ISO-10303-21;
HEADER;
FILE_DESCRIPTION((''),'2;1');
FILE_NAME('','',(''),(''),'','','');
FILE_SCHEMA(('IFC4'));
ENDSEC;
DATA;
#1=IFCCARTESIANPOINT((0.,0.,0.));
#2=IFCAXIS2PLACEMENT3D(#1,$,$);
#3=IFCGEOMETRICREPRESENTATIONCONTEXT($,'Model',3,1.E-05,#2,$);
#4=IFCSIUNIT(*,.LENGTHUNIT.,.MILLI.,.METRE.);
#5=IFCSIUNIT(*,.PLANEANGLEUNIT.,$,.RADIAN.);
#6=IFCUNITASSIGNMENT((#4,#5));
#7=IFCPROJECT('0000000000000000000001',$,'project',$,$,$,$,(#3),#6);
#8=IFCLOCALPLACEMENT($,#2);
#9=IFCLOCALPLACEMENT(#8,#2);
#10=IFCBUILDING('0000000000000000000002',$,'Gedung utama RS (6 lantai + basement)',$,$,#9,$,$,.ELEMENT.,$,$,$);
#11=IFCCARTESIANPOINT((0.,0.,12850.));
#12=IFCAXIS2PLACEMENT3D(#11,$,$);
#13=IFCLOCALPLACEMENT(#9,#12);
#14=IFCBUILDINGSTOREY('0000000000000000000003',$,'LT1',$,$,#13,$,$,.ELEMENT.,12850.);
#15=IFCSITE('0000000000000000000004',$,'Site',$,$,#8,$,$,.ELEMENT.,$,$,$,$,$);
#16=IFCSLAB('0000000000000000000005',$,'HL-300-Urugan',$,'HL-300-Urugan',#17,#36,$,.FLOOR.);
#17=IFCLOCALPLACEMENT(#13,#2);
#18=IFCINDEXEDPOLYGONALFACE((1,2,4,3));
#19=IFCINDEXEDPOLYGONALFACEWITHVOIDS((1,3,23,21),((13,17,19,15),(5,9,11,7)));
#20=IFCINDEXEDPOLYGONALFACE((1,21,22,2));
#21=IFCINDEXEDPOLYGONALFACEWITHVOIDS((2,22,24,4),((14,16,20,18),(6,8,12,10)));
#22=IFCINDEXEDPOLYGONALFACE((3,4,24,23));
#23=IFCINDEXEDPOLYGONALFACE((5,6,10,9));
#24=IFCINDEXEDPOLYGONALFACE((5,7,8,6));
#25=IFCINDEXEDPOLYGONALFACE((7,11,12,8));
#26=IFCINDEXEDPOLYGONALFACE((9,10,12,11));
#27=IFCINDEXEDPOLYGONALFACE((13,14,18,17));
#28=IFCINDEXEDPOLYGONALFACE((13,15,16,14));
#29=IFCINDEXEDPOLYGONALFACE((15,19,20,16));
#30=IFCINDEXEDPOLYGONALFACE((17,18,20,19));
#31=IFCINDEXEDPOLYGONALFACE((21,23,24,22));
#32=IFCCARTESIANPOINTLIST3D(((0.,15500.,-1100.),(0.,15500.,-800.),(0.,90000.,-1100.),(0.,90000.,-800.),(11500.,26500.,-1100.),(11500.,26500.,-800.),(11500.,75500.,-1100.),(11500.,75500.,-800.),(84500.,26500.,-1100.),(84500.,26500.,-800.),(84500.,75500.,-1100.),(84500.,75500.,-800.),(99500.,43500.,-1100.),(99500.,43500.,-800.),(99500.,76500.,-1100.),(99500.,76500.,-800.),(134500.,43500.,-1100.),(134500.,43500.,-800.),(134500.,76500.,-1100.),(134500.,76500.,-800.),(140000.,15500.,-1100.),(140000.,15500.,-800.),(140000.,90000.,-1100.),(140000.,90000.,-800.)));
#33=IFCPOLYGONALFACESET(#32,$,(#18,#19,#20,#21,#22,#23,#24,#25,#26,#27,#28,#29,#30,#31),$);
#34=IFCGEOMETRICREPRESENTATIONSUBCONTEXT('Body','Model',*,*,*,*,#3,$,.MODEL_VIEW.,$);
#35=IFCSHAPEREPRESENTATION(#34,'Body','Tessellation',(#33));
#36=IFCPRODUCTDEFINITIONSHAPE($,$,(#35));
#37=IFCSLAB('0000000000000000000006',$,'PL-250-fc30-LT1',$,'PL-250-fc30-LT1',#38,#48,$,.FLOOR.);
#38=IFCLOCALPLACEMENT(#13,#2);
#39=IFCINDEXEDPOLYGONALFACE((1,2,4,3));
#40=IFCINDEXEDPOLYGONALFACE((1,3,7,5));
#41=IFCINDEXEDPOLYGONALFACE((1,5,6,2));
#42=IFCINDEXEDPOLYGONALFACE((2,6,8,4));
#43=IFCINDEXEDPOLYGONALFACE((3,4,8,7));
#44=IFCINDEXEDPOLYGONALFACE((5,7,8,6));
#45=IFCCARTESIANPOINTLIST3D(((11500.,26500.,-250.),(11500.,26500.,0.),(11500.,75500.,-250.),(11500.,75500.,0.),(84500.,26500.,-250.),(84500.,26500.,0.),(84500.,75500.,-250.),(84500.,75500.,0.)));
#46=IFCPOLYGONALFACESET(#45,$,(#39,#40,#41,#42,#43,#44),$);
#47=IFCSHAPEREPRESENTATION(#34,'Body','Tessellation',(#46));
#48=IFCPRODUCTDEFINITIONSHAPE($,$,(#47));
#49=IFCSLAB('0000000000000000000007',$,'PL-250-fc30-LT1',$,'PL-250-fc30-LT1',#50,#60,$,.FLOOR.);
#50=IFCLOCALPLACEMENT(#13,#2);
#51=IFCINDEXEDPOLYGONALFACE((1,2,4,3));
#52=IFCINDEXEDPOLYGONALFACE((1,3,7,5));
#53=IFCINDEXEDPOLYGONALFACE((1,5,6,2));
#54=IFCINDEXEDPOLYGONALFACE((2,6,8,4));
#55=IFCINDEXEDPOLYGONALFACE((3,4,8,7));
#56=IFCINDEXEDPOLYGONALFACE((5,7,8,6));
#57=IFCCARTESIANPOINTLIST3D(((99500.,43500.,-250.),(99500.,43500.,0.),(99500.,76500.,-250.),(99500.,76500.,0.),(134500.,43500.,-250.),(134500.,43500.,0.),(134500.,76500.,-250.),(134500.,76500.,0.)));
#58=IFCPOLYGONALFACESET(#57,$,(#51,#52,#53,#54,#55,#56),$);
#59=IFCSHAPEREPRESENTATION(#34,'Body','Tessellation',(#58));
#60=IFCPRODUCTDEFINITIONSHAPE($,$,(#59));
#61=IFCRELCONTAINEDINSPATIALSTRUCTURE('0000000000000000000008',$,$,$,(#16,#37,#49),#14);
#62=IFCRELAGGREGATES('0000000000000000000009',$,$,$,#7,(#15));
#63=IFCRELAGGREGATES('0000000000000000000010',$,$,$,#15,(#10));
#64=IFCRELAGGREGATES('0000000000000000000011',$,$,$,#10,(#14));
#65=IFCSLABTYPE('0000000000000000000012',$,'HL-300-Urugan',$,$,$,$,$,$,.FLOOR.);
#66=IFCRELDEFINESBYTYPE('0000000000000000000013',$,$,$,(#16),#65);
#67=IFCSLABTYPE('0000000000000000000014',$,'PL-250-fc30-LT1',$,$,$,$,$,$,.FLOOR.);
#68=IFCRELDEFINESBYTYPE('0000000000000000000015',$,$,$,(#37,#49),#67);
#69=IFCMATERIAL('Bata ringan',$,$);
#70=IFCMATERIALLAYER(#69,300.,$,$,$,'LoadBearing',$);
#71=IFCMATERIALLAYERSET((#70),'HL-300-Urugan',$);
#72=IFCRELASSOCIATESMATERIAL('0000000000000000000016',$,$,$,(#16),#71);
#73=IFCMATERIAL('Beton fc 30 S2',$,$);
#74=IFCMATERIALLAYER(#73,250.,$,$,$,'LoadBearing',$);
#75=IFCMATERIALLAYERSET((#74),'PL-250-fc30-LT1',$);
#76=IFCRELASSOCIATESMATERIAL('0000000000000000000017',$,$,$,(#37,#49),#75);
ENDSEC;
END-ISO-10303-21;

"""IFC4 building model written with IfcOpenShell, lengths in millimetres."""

from ifc_helpers import new_model, si_unit, frame, origin, place, context, subcontext, project, spatial, polyline, outline, extrude, material, layer, layer_set, layer_usage, type_object, element, save


model = new_model("IFC4")

# Units and contexts
model_context = context("Model", 3, precision=1e-05, world=origin())
body_context = subcontext(model_context, "Body", "Model", "MODEL_VIEW")
ifc_project = project(units=[si_unit("LENGTHUNIT", "METRE", prefix="MILLI"), si_unit("PLANEANGLEUNIT", "RADIAN")], contexts=[model_context])

# Site, building, storey
site_placement = place(None, origin())
site = spatial("IfcSite", under=ifc_project, at=site_placement, Name="Site", CompositionType="ELEMENT")
building_placement = place(site_placement, origin())
building = spatial("IfcBuilding", under=site, at=building_placement, Name="Gedung utama RS (6 lantai + basement)", CompositionType="ELEMENT")
storey_placement = place(building_placement, frame((0.0, 0.0, 12850.0)))
storey = spatial("IfcBuildingStorey", under=building, at=storey_placement, Name="LT1", CompositionType="ELEMENT", Elevation=12850.0)

# Shared definitions
ifc_material_1 = material(Name="Beton fc 30 S2")

# Slabs
ifc_material_2 = material(Name="Bata ringan")
ifc_layer_1 = layer(ifc_material_2, 300.0, Category="LoadBearing")
ifc_layer_set_1 = layer_set([ifc_layer_1], Name="HL-300-Urugan")
ifc_layer_usage_1 = layer_usage(ifc_layer_set_1, "AXIS3", "NEGATIVE", -800.0)
slab_type_1 = type_object("IfcSlabType", Name="HL-300-Urugan", PredefinedType="FLOOR")
slab_1_placement = place(storey_placement, origin())
element("IfcSlab", 1, at=slab_1_placement, inside=storey, type_object=slab_type_1, material=ifc_layer_usage_1, Name="HL-300-Urugan", ObjectType="HL-300-Urugan", PredefinedType="FLOOR", context=body_context, shape_type="SweptSolid", body=[
    extrude(outline(polyline([(0.0, 15500.0), (140000.0, 15500.0), (140000.0, 90000.0), (0.0, 90000.0), (0.0, 15500.0)]), holes=[polyline([(11500.0, 26500.0), (84500.0, 26500.0), (84500.0, 75500.0), (11500.0, 75500.0), (11500.0, 26500.0)]), polyline([(99500.0, 43500.0), (134500.0, 43500.0), (134500.0, 76500.0), (99500.0, 76500.0), (99500.0, 43500.0)])]), frame((0.0, 0.0, -1100.0)), (0.0, 0.0, 1.0), 300.0),
])
ifc_layer_2 = layer(ifc_material_1, 250.0, Category="LoadBearing")
ifc_layer_set_2 = layer_set([ifc_layer_2], Name="PL-250-fc30-LT1")
ifc_layer_usage_2 = layer_usage(ifc_layer_set_2, "AXIS3", "NEGATIVE", 0.0)
slab_type_2 = type_object("IfcSlabType", Name="PL-250-fc30-LT1", PredefinedType="FLOOR")
slab_2_placement = place(storey_placement, origin())
element("IfcSlab", 2, at=slab_2_placement, inside=storey, type_object=slab_type_2, material=ifc_layer_usage_2, Name="PL-250-fc30-LT1", ObjectType="PL-250-fc30-LT1", PredefinedType="FLOOR", context=body_context, shape_type="SweptSolid", body=[
    extrude(outline(polyline([(11500.0, 26500.0), (84500.0, 26500.0), (84500.0, 75500.0), (11500.0, 75500.0), (11500.0, 26500.0)])), frame((0.0, 0.0, -250.0)), (0.0, 0.0, 1.0), 250.0),
])
slab_3_placement = place(storey_placement, origin())
element("IfcSlab", 3, at=slab_3_placement, inside=storey, type_object=slab_type_2, material=ifc_layer_usage_2, Name="PL-250-fc30-LT1", ObjectType="PL-250-fc30-LT1", PredefinedType="FLOOR", context=body_context, shape_type="SweptSolid", body=[
    extrude(outline(polyline([(99500.0, 43500.0), (134500.0, 43500.0), (134500.0, 76500.0), (99500.0, 76500.0), (99500.0, 43500.0)])), frame((0.0, 0.0, -250.0)), (0.0, 0.0, 1.0), 250.0),
])

save(model, "model.ifc")
